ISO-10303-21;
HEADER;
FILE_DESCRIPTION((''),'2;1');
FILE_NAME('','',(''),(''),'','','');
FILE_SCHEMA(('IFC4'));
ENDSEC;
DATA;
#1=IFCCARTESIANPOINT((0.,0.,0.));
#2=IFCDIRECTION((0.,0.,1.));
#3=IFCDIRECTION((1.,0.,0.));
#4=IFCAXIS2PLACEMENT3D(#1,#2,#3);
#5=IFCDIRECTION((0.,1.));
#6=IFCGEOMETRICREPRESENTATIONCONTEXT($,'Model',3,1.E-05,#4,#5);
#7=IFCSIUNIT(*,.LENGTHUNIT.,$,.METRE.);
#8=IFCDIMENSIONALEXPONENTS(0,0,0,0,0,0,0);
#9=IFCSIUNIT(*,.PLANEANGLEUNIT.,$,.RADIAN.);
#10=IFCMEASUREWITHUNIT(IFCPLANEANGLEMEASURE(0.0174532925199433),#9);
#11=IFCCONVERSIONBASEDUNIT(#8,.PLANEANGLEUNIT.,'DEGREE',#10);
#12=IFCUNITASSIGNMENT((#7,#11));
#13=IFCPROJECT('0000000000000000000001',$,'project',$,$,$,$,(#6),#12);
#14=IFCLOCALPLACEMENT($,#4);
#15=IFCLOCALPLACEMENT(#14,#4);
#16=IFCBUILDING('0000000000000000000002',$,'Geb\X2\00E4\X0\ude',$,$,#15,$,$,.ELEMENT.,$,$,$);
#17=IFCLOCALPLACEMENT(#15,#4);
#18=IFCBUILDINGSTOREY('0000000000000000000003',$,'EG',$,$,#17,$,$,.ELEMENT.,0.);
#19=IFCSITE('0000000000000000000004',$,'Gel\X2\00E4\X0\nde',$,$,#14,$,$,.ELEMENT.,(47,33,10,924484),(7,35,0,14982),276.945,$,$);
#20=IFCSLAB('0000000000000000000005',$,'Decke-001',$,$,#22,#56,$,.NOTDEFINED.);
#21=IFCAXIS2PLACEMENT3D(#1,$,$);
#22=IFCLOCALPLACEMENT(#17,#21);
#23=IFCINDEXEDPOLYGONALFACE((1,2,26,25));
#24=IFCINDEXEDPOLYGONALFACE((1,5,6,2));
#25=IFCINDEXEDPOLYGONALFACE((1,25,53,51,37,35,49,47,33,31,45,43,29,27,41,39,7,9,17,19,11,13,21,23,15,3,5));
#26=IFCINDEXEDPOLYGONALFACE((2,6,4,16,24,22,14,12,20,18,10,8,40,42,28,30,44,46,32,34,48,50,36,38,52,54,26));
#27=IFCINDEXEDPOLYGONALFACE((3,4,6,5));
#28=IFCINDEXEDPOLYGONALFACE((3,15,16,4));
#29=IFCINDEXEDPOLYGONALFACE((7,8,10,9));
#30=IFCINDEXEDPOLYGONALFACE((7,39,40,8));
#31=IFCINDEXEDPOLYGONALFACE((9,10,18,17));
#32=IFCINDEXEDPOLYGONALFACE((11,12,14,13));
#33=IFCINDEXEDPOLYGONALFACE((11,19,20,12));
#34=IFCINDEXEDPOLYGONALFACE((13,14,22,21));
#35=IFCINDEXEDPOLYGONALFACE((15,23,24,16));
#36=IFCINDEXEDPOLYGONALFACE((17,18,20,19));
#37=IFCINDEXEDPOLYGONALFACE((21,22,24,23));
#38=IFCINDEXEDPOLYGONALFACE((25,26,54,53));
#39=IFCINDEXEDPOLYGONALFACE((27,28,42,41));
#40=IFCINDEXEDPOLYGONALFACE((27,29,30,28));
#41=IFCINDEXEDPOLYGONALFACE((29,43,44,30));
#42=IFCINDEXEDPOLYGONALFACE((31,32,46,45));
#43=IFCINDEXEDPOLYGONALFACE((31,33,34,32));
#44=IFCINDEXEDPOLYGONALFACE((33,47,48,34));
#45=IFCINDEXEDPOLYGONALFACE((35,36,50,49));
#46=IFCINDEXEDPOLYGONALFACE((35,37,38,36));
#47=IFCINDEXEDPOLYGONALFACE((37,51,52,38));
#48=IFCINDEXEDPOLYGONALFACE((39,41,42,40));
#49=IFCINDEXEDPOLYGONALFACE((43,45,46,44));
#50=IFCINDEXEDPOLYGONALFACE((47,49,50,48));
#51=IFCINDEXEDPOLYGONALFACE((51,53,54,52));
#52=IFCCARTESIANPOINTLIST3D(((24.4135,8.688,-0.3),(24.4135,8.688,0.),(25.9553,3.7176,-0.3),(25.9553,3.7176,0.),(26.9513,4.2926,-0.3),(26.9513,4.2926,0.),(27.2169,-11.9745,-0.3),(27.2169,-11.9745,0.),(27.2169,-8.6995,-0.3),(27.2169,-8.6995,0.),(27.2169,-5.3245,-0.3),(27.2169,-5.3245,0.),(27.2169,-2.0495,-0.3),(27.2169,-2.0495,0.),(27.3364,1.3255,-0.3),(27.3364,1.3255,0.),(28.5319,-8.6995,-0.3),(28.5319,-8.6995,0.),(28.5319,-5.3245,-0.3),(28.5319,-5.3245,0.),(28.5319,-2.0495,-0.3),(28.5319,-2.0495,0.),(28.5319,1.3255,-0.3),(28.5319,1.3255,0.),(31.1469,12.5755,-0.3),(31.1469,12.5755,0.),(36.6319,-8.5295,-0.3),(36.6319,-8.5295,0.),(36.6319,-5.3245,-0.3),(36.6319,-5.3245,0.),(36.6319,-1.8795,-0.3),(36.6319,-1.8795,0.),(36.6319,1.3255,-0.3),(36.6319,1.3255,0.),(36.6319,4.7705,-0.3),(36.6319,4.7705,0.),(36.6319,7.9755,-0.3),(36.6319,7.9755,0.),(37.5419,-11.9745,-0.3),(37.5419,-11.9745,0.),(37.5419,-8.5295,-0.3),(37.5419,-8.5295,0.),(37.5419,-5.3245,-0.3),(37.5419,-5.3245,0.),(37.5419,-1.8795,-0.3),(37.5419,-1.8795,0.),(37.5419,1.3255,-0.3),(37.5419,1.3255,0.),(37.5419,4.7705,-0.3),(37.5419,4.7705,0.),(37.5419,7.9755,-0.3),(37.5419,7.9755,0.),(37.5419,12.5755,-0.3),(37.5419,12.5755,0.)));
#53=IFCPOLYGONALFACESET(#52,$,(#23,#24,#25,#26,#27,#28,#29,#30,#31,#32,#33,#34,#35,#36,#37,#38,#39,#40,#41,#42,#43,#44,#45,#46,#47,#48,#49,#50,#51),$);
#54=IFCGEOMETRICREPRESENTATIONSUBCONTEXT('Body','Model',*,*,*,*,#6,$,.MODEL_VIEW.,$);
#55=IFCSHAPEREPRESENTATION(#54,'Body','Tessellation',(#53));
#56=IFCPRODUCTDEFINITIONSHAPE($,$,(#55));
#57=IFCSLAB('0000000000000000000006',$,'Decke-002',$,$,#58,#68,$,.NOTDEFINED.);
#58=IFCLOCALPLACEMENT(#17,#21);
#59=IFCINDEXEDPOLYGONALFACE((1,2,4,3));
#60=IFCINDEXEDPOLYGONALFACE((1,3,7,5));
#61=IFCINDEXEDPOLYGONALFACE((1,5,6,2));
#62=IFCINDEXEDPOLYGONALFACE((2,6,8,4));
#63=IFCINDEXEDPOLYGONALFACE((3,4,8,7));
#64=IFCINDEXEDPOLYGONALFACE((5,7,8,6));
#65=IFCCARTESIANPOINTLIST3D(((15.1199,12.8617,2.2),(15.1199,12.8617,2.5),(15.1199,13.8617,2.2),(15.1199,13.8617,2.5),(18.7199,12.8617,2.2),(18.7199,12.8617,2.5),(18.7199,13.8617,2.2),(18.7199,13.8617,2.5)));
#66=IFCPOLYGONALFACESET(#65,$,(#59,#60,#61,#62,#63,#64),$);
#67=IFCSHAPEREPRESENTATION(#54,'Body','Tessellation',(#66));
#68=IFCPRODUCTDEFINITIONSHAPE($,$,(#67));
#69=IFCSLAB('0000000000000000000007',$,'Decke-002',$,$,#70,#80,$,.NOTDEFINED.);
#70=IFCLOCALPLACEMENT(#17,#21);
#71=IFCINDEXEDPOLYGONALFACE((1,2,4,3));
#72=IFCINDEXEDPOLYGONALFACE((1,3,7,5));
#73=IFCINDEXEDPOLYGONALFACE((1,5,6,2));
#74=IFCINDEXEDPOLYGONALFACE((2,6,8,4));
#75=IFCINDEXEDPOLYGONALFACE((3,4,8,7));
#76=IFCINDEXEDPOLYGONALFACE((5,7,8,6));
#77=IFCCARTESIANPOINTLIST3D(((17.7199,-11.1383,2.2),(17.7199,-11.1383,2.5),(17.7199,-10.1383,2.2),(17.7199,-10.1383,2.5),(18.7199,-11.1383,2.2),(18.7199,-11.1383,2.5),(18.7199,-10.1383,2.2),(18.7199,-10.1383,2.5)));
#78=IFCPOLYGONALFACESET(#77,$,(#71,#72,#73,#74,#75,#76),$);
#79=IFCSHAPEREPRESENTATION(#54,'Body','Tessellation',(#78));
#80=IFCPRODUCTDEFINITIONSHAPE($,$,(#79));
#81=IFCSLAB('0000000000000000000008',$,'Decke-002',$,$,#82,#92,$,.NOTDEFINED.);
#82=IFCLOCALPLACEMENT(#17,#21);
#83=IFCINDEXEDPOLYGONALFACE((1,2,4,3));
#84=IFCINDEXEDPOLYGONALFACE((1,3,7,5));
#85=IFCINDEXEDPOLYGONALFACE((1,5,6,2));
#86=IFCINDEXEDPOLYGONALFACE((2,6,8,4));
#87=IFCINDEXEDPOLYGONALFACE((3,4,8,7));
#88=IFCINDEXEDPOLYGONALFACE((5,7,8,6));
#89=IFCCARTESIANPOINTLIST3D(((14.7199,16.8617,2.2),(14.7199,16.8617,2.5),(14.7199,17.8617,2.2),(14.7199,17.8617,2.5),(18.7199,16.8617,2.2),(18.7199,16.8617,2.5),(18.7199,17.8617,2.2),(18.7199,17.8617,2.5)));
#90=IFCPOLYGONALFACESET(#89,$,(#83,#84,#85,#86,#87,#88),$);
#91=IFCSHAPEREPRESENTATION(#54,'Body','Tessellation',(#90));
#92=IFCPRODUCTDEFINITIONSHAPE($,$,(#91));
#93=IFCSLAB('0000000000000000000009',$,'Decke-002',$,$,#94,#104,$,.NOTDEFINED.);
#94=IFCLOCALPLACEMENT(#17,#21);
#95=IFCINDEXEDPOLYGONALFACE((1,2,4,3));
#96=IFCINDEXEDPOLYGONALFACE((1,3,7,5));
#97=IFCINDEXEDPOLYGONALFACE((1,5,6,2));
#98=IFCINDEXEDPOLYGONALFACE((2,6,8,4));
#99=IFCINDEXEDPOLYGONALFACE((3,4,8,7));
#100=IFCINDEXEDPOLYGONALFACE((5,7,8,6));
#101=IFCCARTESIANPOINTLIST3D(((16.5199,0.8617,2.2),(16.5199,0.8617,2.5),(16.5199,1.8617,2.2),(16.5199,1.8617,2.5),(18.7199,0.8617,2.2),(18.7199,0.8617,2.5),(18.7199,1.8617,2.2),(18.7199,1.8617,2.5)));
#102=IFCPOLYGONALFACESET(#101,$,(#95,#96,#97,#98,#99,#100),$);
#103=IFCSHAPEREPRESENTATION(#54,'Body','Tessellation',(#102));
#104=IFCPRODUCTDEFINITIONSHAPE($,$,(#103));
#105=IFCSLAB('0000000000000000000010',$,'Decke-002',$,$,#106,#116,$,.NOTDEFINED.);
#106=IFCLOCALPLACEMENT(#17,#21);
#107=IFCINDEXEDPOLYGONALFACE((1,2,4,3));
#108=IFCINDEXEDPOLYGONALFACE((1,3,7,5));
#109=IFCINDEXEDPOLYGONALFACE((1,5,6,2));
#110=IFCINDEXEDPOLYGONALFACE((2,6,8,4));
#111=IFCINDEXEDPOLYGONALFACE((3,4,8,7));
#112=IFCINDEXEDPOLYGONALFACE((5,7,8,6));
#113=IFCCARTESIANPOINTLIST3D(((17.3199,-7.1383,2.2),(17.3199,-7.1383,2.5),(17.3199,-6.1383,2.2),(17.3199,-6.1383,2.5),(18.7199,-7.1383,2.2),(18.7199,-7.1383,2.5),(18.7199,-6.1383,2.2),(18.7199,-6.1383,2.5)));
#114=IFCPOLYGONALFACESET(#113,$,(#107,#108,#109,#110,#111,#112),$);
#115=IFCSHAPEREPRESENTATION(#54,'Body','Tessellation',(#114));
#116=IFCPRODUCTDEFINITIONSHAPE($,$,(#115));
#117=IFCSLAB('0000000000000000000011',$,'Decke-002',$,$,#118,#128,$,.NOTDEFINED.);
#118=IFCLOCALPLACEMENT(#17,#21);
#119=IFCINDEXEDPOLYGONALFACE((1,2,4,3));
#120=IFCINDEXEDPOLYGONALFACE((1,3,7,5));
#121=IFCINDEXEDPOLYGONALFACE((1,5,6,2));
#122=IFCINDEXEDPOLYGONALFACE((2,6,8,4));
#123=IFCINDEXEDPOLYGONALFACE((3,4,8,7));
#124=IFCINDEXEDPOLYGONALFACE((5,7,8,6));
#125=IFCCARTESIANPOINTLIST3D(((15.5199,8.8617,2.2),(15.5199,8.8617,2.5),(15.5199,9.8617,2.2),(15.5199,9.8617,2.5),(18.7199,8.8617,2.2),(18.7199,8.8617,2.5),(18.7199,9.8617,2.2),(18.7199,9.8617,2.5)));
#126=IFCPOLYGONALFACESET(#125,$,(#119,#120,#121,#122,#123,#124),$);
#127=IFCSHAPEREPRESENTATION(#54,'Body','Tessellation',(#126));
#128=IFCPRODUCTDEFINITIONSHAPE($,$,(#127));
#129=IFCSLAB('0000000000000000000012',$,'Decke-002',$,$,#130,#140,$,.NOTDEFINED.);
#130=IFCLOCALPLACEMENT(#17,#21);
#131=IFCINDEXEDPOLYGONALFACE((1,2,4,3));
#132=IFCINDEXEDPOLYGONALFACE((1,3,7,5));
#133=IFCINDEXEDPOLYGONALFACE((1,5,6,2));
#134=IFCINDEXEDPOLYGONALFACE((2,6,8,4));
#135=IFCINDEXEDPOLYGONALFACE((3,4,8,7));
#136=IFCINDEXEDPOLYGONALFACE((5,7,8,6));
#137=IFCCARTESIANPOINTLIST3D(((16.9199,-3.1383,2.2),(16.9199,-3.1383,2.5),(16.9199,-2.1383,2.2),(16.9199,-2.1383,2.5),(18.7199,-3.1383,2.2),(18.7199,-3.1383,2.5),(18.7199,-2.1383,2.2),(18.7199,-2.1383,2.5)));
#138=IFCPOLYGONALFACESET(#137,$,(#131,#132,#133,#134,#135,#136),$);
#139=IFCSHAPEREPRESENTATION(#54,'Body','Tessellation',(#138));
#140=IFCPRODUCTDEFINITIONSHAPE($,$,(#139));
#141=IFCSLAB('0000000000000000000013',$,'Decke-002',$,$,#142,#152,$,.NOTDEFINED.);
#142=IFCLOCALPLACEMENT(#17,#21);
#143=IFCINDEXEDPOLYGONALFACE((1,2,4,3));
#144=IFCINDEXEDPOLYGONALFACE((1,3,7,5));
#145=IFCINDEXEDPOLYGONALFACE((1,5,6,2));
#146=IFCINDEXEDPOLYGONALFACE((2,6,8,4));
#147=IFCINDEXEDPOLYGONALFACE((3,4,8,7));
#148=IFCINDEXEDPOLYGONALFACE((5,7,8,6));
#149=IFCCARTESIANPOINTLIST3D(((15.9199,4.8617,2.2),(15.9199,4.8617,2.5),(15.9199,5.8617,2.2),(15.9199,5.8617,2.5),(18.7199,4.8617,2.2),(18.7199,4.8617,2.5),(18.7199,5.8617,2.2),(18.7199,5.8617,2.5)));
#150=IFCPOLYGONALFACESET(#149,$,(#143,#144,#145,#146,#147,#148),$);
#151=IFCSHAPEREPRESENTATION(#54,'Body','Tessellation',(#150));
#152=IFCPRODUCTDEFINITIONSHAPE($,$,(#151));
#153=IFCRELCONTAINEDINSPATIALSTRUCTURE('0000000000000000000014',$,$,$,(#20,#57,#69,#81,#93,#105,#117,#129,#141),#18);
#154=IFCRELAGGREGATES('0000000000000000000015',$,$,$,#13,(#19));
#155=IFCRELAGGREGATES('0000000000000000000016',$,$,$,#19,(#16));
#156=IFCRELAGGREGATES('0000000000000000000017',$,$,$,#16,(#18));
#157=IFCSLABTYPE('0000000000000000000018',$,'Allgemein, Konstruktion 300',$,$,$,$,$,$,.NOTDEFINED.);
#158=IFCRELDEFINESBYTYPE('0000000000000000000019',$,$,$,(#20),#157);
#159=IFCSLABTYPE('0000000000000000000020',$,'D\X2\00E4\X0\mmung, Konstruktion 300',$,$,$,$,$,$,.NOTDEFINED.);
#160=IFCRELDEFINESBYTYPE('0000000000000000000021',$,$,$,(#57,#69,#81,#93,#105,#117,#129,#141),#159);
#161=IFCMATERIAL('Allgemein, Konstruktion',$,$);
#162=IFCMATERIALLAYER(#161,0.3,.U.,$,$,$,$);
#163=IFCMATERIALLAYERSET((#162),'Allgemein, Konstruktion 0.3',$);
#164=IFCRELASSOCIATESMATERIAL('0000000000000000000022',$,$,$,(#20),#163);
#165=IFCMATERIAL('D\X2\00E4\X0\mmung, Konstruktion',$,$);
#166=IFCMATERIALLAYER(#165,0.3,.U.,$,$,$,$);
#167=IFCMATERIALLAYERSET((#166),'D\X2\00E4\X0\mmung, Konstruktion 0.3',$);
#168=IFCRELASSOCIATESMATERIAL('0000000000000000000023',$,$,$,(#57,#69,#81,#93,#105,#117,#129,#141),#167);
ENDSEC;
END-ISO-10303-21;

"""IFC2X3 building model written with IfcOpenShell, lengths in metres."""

from ifc_helpers import new_model, entity, si_unit, converted_unit, direction, frame, origin_with_axes, place, context, subcontext, project, spatial, polyline, outline, extrude, material, layer, layer_set, layer_usage, type_object, element, save


model = new_model("IFC2X3")

# Units and contexts
model_context = context("Model", 3, precision=1e-05, world=origin_with_axes(), true_north=direction((0.0, 1.0)))
body_context = subcontext(model_context, "Body", "Model", "MODEL_VIEW")
ifc_project = project(units=[si_unit("LENGTHUNIT", "METRE"), converted_unit("PLANEANGLEUNIT", "DEGREE", entity("IfcPlaneAngleMeasure", 0.0174532925199433), si_unit("PLANEANGLEUNIT", "RADIAN"), dimensions=[0, 0, 0, 0, 0, 0, 0])], contexts=[model_context])

# Site, building, storey
site_placement = place(None, origin_with_axes())
site = spatial("IfcSite", under=ifc_project, at=site_placement, Name="Gelände", CompositionType="ELEMENT", RefLatitude=(47, 33, 10, 924484), RefLongitude=(7, 35, 0, 14982), RefElevation=276.945)
building_placement = place(site_placement, origin_with_axes())
building = spatial("IfcBuilding", under=site, at=building_placement, Name="Gebäude", CompositionType="ELEMENT")
storey_placement = place(building_placement, origin_with_axes())
storey = spatial("IfcBuildingStorey", under=building, at=storey_placement, Name="EG", CompositionType="ELEMENT", Elevation=0.0)

# Slabs
ifc_material_1 = material(Name="Allgemein, Konstruktion")
ifc_layer_1 = layer(ifc_material_1, 0.3, ventilated="UNKNOWN")
ifc_layer_set_1 = layer_set([ifc_layer_1], Name="Allgemein, Konstruktion 0.3")
ifc_layer_usage_1 = layer_usage(ifc_layer_set_1, "AXIS3", "NEGATIVE", 0.3)
slab_type_1 = type_object("IfcSlabType", Name="Allgemein, Konstruktion 300", PredefinedType="NOTDEFINED")
slab_1_placement = place(storey_placement, frame((31.1469, 12.5755, 0.0), z_axis=(0.0, 0.0, 1.0), x_axis=(1.0, 0.0, 0.0)))
element("IfcSlab", 1, at=slab_1_placement, inside=storey, type_object=slab_type_1, material=ifc_layer_usage_1, Name="Decke-001", PredefinedType="NOTDEFINED", context=body_context, shape_type="SweptSolid", body=[
    extrude(outline(polyline([(0.0, 0.0), (-6.7333, -3.8875), (-4.1956, -8.283), (-5.1916, -8.858), (-3.8105, -11.25), (-2.615, -11.25), (-2.615, -14.625), (-3.93, -14.625), (-3.93, -17.9), (-2.615, -17.9), (-2.615, -21.275), (-3.93, -21.275), (-3.93, -24.55), (6.395, -24.55), (6.395, -21.105), (5.485, -21.105), (5.485, -17.9), (6.395, -17.9), (6.395, -14.455), (5.485, -14.455), (5.485, -11.25), (6.395, -11.25), (6.395, -7.805), (5.485, -7.805), (5.485, -4.6), (6.395, -4.6), (6.395, 0.0), (0.0, 0.0)])), frame((0.0, 0.0, -0.3), z_axis=(0.0, 0.0, 1.0), x_axis=(1.0, 0.0, 0.0)), (0.0, 0.0, 1.0), 0.3),
])
ifc_material_2 = material(Name="Dämmung, Konstruktion")
ifc_layer_2 = layer(ifc_material_2, 0.3, ventilated="UNKNOWN")
ifc_layer_set_2 = layer_set([ifc_layer_2], Name="Dämmung, Konstruktion 0.3")
ifc_layer_usage_2 = layer_usage(ifc_layer_set_2, "AXIS3", "NEGATIVE", 0.3)
slab_type_2 = type_object("IfcSlabType", Name="Dämmung, Konstruktion 300", PredefinedType="NOTDEFINED")
slab_2_placement = place(storey_placement, frame((18.7199, 12.8617, 2.5), z_axis=(0.0, 0.0, 1.0), x_axis=(1.0, 0.0, 0.0)))
element("IfcSlab", 2, at=slab_2_placement, inside=storey, type_object=slab_type_2, material=ifc_layer_usage_2, Name="Decke-002", PredefinedType="NOTDEFINED", context=body_context, shape_type="SweptSolid", body=[
    extrude(outline(polyline([(0.0, 0.0), (0.0, 1.0), (-3.6, 1.0), (-3.6, 0.0), (0.0, 0.0)])), frame((0.0, 0.0, -0.3), z_axis=(0.0, 0.0, 1.0), x_axis=(1.0, 0.0, 0.0)), (0.0, 0.0, 1.0), 0.3),
])
ifc_layer_usage_3 = layer_usage(ifc_layer_set_2, "AXIS3", "NEGATIVE", 0.3)
slab_3_placement = place(storey_placement, frame((18.7199, -11.1383, 2.5), z_axis=(0.0, 0.0, 1.0), x_axis=(1.0, 0.0, 0.0)))
element("IfcSlab", 3, at=slab_3_placement, inside=storey, type_object=slab_type_2, material=ifc_layer_usage_3, Name="Decke-002", PredefinedType="NOTDEFINED", context=body_context, shape_type="SweptSolid", body=[
    extrude(outline(polyline([(0.0, 0.0), (0.0, 1.0), (-1.0, 1.0), (-1.0, 0.0), (0.0, 0.0)])), frame((0.0, 0.0, -0.3), z_axis=(0.0, 0.0, 1.0), x_axis=(1.0, 0.0, 0.0)), (0.0, 0.0, 1.0), 0.3),
])
ifc_layer_usage_4 = layer_usage(ifc_layer_set_2, "AXIS3", "NEGATIVE", 0.3)
slab_4_placement = place(storey_placement, frame((18.7199, 16.8617, 2.5), z_axis=(0.0, 0.0, 1.0), x_axis=(1.0, 0.0, 0.0)))
element("IfcSlab", 4, at=slab_4_placement, inside=storey, type_object=slab_type_2, material=ifc_layer_usage_4, Name="Decke-002", PredefinedType="NOTDEFINED", context=body_context, shape_type="SweptSolid", body=[
    extrude(outline(polyline([(0.0, 0.0), (0.0, 1.0), (-4.0, 1.0), (-4.0, 0.0), (0.0, 0.0)])), frame((0.0, 0.0, -0.3), z_axis=(0.0, 0.0, 1.0), x_axis=(1.0, 0.0, 0.0)), (0.0, 0.0, 1.0), 0.3),
])
ifc_layer_usage_5 = layer_usage(ifc_layer_set_2, "AXIS3", "NEGATIVE", 0.3)
slab_5_placement = place(storey_placement, frame((18.7199, 0.8617, 2.5), z_axis=(0.0, 0.0, 1.0), x_axis=(1.0, 0.0, 0.0)))
element("IfcSlab", 5, at=slab_5_placement, inside=storey, type_object=slab_type_2, material=ifc_layer_usage_5, Name="Decke-002", PredefinedType="NOTDEFINED", context=body_context, shape_type="SweptSolid", body=[
    extrude(outline(polyline([(0.0, 0.0), (0.0, 1.0), (-2.2, 1.0), (-2.2, 0.0), (0.0, 0.0)])), frame((0.0, 0.0, -0.3), z_axis=(0.0, 0.0, 1.0), x_axis=(1.0, 0.0, 0.0)), (0.0, 0.0, 1.0), 0.3),
])
ifc_layer_usage_6 = layer_usage(ifc_layer_set_2, "AXIS3", "NEGATIVE", 0.3)
slab_6_placement = place(storey_placement, frame((18.7199, -7.1383, 2.5), z_axis=(0.0, 0.0, 1.0), x_axis=(1.0, 0.0, 0.0)))
element("IfcSlab", 6, at=slab_6_placement, inside=storey, type_object=slab_type_2, material=ifc_layer_usage_6, Name="Decke-002", PredefinedType="NOTDEFINED", context=body_context, shape_type="SweptSolid", body=[
    extrude(outline(polyline([(0.0, 0.0), (0.0, 1.0), (-1.4, 1.0), (-1.4, 0.0), (0.0, 0.0)])), frame((0.0, 0.0, -0.3), z_axis=(0.0, 0.0, 1.0), x_axis=(1.0, 0.0, 0.0)), (0.0, 0.0, 1.0), 0.3),
])
ifc_layer_usage_7 = layer_usage(ifc_layer_set_2, "AXIS3", "NEGATIVE", 0.3)
slab_7_placement = place(storey_placement, frame((18.7199, 8.8617, 2.5), z_axis=(0.0, 0.0, 1.0), x_axis=(1.0, 0.0, 0.0)))
element("IfcSlab", 7, at=slab_7_placement, inside=storey, type_object=slab_type_2, material=ifc_layer_usage_7, Name="Decke-002", PredefinedType="NOTDEFINED", context=body_context, shape_type="SweptSolid", body=[
    extrude(outline(polyline([(0.0, 0.0), (0.0, 1.0), (-3.2, 1.0), (-3.2, 0.0), (0.0, 0.0)])), frame((0.0, 0.0, -0.3), z_axis=(0.0, 0.0, 1.0), x_axis=(1.0, 0.0, 0.0)), (0.0, 0.0, 1.0), 0.3),
])
ifc_layer_usage_8 = layer_usage(ifc_layer_set_2, "AXIS3", "NEGATIVE", 0.3)
slab_8_placement = place(storey_placement, frame((18.7199, -3.1383, 2.5), z_axis=(0.0, 0.0, 1.0), x_axis=(1.0, 0.0, 0.0)))
element("IfcSlab", 8, at=slab_8_placement, inside=storey, type_object=slab_type_2, material=ifc_layer_usage_8, Name="Decke-002", PredefinedType="NOTDEFINED", context=body_context, shape_type="SweptSolid", body=[
    extrude(outline(polyline([(0.0, 0.0), (0.0, 1.0), (-1.8, 1.0), (-1.8, 0.0), (0.0, 0.0)])), frame((0.0, 0.0, -0.3), z_axis=(0.0, 0.0, 1.0), x_axis=(1.0, 0.0, 0.0)), (0.0, 0.0, 1.0), 0.3),
])
ifc_layer_usage_9 = layer_usage(ifc_layer_set_2, "AXIS3", "NEGATIVE", 0.3)
slab_9_placement = place(storey_placement, frame((18.7199, 4.8617, 2.5), z_axis=(0.0, 0.0, 1.0), x_axis=(1.0, 0.0, 0.0)))
element("IfcSlab", 9, at=slab_9_placement, inside=storey, type_object=slab_type_2, material=ifc_layer_usage_9, Name="Decke-002", PredefinedType="NOTDEFINED", context=body_context, shape_type="SweptSolid", body=[
    extrude(outline(polyline([(0.0, 0.0), (0.0, 1.0), (-2.8, 1.0), (-2.8, 0.0), (0.0, 0.0)])), frame((0.0, 0.0, -0.3), z_axis=(0.0, 0.0, 1.0), x_axis=(1.0, 0.0, 0.0)), (0.0, 0.0, 1.0), 0.3),
])

save(model, "model.ifc")
